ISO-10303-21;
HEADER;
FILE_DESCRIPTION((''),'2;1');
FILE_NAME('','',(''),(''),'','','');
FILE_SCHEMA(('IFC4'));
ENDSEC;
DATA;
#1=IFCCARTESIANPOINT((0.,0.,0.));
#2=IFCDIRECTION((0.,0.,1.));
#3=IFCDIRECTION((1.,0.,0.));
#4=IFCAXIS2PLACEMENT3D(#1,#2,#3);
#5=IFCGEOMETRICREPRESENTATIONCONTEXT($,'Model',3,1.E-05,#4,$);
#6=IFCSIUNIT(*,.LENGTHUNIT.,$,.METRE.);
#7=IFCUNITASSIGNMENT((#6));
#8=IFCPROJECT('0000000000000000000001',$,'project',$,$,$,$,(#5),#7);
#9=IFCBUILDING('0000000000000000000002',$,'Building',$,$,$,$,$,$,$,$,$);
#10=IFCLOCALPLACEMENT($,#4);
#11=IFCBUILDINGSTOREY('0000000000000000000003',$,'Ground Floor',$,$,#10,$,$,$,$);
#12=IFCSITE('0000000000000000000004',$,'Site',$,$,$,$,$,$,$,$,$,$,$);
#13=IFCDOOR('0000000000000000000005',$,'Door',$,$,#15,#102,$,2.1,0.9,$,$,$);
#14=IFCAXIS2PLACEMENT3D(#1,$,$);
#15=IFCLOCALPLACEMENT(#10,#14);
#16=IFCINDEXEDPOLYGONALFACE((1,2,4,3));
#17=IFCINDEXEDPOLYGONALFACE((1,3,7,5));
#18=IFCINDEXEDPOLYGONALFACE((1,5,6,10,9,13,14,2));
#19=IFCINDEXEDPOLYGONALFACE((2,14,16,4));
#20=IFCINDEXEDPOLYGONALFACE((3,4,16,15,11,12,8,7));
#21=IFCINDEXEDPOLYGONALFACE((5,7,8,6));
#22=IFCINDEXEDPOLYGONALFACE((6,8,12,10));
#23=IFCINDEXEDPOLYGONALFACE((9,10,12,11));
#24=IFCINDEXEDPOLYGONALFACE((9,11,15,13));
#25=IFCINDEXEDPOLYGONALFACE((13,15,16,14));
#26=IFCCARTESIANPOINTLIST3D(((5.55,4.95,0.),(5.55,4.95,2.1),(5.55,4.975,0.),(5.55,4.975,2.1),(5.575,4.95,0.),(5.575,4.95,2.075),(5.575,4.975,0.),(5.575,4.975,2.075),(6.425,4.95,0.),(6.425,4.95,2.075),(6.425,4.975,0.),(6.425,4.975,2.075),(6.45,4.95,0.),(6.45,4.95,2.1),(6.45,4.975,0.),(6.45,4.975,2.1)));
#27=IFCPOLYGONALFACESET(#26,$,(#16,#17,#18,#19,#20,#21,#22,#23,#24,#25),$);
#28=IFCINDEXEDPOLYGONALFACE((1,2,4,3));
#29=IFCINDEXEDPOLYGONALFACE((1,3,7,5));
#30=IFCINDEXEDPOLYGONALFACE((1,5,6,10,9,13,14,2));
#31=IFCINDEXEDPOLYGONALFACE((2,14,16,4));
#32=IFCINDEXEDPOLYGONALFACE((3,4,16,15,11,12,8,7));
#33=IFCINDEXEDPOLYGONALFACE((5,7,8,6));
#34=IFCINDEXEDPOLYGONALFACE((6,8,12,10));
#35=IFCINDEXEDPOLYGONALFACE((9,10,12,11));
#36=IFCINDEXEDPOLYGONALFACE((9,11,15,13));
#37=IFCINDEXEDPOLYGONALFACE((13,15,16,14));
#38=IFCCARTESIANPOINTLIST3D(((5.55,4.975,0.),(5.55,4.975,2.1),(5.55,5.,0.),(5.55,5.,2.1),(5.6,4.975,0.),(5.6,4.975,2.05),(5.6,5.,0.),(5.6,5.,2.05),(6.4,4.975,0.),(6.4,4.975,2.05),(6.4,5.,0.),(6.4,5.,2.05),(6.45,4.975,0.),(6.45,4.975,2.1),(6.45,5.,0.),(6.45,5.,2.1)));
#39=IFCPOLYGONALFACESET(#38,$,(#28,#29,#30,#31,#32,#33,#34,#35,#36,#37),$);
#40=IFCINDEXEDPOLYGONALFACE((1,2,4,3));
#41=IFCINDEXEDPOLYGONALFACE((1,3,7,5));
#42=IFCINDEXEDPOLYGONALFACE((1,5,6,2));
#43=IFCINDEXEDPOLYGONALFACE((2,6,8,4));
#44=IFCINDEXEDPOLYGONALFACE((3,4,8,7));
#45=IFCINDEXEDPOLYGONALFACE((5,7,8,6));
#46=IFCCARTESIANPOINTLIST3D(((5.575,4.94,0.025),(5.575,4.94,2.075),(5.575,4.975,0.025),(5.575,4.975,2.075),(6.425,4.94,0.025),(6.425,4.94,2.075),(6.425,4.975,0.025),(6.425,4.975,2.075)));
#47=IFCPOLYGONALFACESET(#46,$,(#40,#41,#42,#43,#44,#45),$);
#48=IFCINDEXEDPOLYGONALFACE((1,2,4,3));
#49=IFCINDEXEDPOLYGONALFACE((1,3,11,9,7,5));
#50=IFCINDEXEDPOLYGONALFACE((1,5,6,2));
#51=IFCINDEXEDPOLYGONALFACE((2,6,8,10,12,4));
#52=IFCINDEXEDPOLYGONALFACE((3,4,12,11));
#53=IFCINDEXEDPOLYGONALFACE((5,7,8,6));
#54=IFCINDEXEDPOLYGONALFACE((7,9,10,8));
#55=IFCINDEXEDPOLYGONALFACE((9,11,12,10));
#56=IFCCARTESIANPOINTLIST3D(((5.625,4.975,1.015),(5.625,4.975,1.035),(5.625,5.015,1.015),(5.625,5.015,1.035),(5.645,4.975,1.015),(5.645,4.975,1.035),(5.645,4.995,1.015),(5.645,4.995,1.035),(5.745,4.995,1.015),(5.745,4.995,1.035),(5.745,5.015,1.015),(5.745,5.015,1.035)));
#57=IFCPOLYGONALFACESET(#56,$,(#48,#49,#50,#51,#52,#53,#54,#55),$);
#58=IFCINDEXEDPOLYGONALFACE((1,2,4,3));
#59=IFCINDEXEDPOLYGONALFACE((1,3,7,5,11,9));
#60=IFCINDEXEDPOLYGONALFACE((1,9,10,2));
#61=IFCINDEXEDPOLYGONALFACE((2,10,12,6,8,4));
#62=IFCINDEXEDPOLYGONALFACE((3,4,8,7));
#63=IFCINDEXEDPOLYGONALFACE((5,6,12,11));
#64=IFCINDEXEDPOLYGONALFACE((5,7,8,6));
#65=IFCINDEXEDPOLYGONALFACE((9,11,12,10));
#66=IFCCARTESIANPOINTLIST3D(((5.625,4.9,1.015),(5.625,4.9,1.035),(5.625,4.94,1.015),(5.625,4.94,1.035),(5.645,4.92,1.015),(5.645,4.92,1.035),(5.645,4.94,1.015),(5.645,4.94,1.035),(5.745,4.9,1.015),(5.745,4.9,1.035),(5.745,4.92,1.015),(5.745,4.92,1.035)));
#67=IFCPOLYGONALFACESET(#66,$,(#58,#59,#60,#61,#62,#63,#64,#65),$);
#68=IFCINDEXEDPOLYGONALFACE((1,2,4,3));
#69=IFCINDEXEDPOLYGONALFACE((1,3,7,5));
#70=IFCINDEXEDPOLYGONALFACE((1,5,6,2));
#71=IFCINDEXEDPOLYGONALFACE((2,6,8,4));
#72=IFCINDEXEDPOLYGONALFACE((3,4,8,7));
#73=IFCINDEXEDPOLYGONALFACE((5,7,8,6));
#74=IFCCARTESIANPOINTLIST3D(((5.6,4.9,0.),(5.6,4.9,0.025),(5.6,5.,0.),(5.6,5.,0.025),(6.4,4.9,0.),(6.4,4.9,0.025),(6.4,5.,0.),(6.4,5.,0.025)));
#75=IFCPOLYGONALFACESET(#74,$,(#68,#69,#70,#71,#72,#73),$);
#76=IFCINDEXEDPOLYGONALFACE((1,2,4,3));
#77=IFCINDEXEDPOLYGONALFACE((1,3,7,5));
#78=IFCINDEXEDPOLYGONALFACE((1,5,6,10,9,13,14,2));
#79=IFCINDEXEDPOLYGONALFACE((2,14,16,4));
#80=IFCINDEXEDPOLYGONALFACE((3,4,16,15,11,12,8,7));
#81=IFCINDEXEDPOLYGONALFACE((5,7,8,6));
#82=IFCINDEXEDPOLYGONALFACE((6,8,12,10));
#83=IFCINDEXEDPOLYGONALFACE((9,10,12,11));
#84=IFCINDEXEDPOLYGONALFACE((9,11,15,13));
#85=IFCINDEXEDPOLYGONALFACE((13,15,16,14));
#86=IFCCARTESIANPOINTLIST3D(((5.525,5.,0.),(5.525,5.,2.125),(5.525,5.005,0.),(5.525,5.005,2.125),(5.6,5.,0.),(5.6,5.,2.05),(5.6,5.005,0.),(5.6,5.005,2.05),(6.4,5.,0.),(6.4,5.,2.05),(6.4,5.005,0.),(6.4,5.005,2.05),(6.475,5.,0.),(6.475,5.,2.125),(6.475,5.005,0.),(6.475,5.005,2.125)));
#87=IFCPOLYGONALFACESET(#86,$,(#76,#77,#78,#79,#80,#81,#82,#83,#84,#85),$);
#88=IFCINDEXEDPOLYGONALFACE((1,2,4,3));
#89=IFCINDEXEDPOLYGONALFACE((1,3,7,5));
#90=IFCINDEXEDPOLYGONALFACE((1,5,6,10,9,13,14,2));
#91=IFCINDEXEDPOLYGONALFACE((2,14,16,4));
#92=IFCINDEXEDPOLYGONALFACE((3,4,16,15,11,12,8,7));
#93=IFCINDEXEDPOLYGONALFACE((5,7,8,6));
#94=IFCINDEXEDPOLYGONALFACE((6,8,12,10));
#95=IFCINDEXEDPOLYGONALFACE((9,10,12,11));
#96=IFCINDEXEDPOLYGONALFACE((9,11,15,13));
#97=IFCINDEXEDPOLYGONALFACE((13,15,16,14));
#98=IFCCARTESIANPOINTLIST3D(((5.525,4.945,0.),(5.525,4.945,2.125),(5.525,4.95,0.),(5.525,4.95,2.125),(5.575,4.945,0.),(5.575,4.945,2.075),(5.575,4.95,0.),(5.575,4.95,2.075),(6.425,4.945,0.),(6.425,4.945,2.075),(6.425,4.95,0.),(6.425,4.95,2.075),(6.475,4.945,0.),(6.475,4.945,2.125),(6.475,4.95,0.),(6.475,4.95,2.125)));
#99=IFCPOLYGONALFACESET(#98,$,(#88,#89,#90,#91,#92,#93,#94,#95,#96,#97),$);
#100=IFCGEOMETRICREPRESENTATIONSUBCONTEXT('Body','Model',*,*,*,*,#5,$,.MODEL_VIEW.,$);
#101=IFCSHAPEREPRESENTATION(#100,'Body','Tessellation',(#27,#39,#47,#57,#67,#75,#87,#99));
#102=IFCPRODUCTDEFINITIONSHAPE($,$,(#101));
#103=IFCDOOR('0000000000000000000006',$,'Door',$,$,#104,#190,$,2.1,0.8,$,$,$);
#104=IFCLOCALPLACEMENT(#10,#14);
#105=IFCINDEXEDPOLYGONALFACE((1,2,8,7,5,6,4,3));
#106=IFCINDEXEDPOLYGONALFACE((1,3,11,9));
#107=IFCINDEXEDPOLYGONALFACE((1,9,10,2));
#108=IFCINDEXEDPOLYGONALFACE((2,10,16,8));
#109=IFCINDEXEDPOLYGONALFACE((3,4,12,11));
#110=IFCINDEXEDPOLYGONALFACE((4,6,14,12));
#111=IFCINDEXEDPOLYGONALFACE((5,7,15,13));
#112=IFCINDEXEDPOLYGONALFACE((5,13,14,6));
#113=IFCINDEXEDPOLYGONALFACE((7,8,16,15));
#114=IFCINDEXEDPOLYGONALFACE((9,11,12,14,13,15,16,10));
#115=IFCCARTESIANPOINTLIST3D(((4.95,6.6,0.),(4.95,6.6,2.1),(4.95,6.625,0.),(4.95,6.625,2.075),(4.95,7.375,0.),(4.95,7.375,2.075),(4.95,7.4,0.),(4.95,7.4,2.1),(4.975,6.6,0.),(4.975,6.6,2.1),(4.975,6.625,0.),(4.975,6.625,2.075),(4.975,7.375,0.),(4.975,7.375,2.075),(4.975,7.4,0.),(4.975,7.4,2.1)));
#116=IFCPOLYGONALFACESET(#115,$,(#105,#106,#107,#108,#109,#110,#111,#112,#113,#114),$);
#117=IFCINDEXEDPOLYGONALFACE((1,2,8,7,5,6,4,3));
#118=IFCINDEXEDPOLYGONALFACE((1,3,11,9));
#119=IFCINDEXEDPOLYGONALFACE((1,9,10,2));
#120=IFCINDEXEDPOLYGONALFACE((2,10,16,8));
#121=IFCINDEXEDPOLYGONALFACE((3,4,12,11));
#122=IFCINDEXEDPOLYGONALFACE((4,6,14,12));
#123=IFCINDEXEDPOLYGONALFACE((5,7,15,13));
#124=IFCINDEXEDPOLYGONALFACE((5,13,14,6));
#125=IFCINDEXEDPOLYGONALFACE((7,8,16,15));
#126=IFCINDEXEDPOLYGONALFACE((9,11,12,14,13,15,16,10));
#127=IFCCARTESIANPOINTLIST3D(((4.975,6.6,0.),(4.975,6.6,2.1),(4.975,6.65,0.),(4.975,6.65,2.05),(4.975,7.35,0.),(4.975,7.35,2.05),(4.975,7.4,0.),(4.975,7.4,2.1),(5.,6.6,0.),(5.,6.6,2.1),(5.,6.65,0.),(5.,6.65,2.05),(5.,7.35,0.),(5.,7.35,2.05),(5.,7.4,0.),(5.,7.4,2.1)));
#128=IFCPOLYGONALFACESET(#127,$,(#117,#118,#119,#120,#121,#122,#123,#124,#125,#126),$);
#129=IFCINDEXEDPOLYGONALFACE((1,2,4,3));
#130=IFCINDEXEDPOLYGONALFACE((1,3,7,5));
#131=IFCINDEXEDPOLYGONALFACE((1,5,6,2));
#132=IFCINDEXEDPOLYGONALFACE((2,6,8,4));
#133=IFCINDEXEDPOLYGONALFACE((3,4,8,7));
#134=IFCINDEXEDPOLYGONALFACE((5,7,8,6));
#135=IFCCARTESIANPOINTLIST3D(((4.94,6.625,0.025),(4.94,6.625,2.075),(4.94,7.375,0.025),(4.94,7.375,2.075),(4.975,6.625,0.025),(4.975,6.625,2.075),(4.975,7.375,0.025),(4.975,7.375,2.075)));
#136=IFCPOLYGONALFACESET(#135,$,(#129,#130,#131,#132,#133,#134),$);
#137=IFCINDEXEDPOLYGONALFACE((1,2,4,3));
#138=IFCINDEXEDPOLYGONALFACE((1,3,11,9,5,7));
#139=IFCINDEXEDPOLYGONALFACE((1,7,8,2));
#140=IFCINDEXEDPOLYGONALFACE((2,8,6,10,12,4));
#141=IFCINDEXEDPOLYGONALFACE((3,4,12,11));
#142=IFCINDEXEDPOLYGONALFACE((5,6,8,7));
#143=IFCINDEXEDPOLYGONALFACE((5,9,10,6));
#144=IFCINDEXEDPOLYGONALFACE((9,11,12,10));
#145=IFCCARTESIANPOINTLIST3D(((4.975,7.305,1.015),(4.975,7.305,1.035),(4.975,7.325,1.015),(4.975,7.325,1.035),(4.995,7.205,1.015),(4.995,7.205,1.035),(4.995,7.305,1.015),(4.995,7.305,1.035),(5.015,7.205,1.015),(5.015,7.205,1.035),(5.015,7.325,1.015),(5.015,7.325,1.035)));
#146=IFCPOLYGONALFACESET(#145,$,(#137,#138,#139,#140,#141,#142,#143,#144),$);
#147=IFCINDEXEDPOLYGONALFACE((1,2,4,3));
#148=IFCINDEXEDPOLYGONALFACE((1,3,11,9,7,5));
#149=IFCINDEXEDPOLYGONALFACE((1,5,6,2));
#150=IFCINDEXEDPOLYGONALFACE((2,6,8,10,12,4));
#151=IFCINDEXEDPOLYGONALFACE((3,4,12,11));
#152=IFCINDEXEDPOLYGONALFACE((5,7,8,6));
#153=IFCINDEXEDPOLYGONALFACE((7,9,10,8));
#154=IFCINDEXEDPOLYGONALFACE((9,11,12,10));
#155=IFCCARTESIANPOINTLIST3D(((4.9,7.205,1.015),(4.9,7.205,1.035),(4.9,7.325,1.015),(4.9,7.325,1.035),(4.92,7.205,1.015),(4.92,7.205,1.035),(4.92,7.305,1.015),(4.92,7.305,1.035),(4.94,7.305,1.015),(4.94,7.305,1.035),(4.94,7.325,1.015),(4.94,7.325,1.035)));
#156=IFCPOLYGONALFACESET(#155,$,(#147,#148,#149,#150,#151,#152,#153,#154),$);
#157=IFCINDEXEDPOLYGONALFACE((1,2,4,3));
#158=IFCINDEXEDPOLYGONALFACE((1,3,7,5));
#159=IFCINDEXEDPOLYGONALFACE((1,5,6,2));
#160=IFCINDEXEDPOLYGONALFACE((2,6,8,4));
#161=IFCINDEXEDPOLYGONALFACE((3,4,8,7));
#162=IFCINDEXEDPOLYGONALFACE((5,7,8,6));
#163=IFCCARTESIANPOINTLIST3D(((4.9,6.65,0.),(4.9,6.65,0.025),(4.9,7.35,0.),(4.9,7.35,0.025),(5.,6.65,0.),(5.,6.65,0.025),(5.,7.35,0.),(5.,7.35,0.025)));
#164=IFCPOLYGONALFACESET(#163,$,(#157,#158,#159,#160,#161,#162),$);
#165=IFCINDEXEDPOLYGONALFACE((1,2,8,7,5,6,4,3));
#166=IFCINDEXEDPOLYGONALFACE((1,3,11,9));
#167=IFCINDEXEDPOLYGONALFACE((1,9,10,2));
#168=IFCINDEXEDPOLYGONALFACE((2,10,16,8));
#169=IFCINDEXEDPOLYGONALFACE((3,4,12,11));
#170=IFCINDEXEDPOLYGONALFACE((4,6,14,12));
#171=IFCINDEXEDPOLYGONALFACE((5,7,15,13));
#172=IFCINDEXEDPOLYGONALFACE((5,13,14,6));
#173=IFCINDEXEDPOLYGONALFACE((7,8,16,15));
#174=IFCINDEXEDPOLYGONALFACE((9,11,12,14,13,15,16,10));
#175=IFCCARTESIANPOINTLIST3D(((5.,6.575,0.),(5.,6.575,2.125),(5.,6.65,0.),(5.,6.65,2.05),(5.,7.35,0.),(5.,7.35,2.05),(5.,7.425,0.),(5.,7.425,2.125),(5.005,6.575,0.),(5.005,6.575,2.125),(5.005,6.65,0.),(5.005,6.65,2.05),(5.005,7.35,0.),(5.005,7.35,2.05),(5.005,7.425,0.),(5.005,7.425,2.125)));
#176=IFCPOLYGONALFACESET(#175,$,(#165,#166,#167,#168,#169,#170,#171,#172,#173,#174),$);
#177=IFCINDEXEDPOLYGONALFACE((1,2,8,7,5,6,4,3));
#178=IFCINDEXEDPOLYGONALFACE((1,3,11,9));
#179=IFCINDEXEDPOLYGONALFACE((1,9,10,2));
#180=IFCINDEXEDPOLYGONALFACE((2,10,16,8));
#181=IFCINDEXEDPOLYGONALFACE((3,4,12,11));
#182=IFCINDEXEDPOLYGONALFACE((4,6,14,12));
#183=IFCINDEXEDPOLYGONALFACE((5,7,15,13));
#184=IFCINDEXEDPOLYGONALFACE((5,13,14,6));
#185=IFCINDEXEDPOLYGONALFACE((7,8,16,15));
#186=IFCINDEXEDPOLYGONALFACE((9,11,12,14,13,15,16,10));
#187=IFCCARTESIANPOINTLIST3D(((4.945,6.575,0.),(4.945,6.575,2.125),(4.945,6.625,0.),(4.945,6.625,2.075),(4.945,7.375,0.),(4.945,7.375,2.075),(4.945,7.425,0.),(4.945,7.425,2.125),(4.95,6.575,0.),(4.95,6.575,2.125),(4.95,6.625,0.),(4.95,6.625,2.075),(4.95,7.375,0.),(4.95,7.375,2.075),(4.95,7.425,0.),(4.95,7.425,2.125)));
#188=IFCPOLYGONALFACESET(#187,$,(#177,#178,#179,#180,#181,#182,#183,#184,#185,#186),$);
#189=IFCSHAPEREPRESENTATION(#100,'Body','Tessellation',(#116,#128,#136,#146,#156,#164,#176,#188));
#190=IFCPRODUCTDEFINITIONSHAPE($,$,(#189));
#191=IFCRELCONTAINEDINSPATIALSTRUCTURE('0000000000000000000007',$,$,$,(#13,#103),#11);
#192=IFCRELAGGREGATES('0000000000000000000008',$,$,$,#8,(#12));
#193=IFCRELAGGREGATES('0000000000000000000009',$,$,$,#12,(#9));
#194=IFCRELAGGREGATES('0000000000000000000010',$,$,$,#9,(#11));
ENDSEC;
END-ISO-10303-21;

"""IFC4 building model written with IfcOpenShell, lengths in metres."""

from ifc_helpers import new_model, si_unit, frame, origin_with_axes, place, context, subcontext, project, spatial, line, indexed_curve, outline, extrude, element, save


model = new_model("IFC4")

# Units and contexts
model_context = context("Model", 3, precision=1e-05, world=origin_with_axes())
body_context = subcontext(model_context, "Body", "Model", "MODEL_VIEW")
ifc_project = project(units=[si_unit("LENGTHUNIT", "METRE")], contexts=[model_context])

# Site, building, storey
site = spatial("IfcSite", under=ifc_project, Name="Site")
building = spatial("IfcBuilding", under=site, Name="Building")
storey_placement = place(None, origin_with_axes())
storey = spatial("IfcBuildingStorey", under=building, at=storey_placement, Name="Ground Floor")

# Doors
door_1_placement = place(storey_placement, frame((6.45, 5.0, 0.0), z_axis=(0.0, 0.0, 1.0), x_axis=(-1.0, 0.0, 0.0)))
element("IfcDoor", 1, at=door_1_placement, inside=storey, Name="Door", OverallHeight=2.1, OverallWidth=0.9, context=body_context, shape_type="SweptSolid", body=[
    extrude(outline(indexed_curve([(0.0, 0.0), (0.0, 2.1), (0.9, 2.1), (0.9, 0.0), (0.875, 0.0), (0.875, 2.075), (0.025, 2.075), (0.025, 0.0)], segments=[line(1, 2, 3, 4, 5, 6, 7, 8, 1)])), frame((0.0, 0.025, 0.0), z_axis=(0.0, -1.0, 0.0), x_axis=(1.0, 0.0, 0.0)), (0.0, 0.0, -1.0), 0.025),
    extrude(outline(indexed_curve([(0.0, 0.0), (0.0, 2.1), (0.9, 2.1), (0.9, 0.0), (0.85, 0.0), (0.85, 2.05), (0.05, 2.05), (0.05, 0.0)], segments=[line(1, 2, 3, 4, 5, 6, 7, 8, 1)])), frame((0.0, 0.0, 0.0), z_axis=(0.0, -1.0, 0.0), x_axis=(1.0, 0.0, 0.0)), (0.0, 0.0, -1.0), 0.025),
    extrude(outline(indexed_curve([(0.0, 0.0), (0.85, 0.0), (0.85, 0.035), (0.0, 0.035)], segments=[line(1, 2, 3, 4, 1)])), frame((0.025, 0.025, 0.025), z_axis=(0.0, 0.0, 1.0), x_axis=(1.0, 0.0, 0.0)), (0.0, 0.0, 1.0), 2.05),
    extrude(outline(indexed_curve([(0.0, 0.0), (0.0, -0.04), (-0.12, -0.04), (-0.12, -0.02), (-0.02, -0.02), (-0.02, 0.0)], segments=[line(1, 2, 3, 4, 5, 6, 1)])), frame((0.825, 0.025, 1.015), z_axis=(0.0, 0.0, 1.0), x_axis=(1.0, 0.0, 0.0)), (0.0, 0.0, 1.0), 0.02),
    extrude(outline(indexed_curve([(0.0, 0.0), (0.0, 0.04), (-0.12, 0.04), (-0.12, 0.02), (-0.02, 0.02), (-0.02, 0.0)], segments=[line(1, 2, 3, 4, 5, 6, 1)])), frame((0.825, 0.06, 1.015), z_axis=(0.0, 0.0, 1.0), x_axis=(1.0, 0.0, 0.0)), (0.0, 0.0, 1.0), 0.02),
    extrude(outline(indexed_curve([(0.0, 0.0), (0.8, 0.0), (0.8, 0.1), (0.0, 0.1)], segments=[line(1, 2, 3, 4, 1)])), frame((0.05, 0.0, 0.0), z_axis=(0.0, 0.0, 1.0), x_axis=(1.0, 0.0, 0.0)), (0.0, 0.0, 1.0), 0.025),
    extrude(outline(indexed_curve([(0.0, 0.0), (0.0, 2.125), (0.95, 2.125), (0.95, 0.0), (0.875, 0.0), (0.875, 2.05), (0.075, 2.05), (0.075, 0.0)], segments=[line(1, 2, 3, 4, 5, 6, 7, 8, 1)])), frame((-0.025, -0.005, 0.0), z_axis=(0.0, -1.0, 0.0), x_axis=(1.0, 0.0, 0.0)), (0.0, 0.0, -1.0), 0.005),
    extrude(outline(indexed_curve([(0.0, 0.0), (0.0, 2.125), (0.95, 2.125), (0.95, 0.0), (0.9, 0.0), (0.9, 2.075), (0.05, 2.075), (0.05, 0.0)], segments=[line(1, 2, 3, 4, 5, 6, 7, 8, 1)])), frame((-0.025, 0.05, 0.0), z_axis=(0.0, -1.0, 0.0), x_axis=(1.0, 0.0, 0.0)), (0.0, 0.0, -1.0), 0.005),
])
door_2_placement = place(storey_placement, frame((5.0, 6.6, 0.0), z_axis=(0.0, 0.0, 1.0), x_axis=(0.0, 1.0, 0.0)))
element("IfcDoor", 2, at=door_2_placement, inside=storey, Name="Door", OverallHeight=2.1, OverallWidth=0.8, context=body_context, shape_type="SweptSolid", body=[
    extrude(outline(indexed_curve([(0.0, 0.0), (0.0, 2.1), (0.8, 2.1), (0.8, 0.0), (0.775, 0.0), (0.775, 2.075), (0.025, 2.075), (0.025, 0.0)], segments=[line(1, 2, 3, 4, 5, 6, 7, 8, 1)])), frame((0.0, 0.025, 0.0), z_axis=(0.0, -1.0, 0.0), x_axis=(1.0, 0.0, 0.0)), (0.0, 0.0, -1.0), 0.025),
    extrude(outline(indexed_curve([(0.0, 0.0), (0.0, 2.1), (0.8, 2.1), (0.8, 0.0), (0.75, 0.0), (0.75, 2.05), (0.05, 2.05), (0.05, 0.0)], segments=[line(1, 2, 3, 4, 5, 6, 7, 8, 1)])), frame((0.0, 0.0, 0.0), z_axis=(0.0, -1.0, 0.0), x_axis=(1.0, 0.0, 0.0)), (0.0, 0.0, -1.0), 0.025),
    extrude(outline(indexed_curve([(0.0, 0.0), (0.75, 0.0), (0.75, 0.035), (0.0, 0.035)], segments=[line(1, 2, 3, 4, 1)])), frame((0.025, 0.025, 0.025), z_axis=(0.0, 0.0, 1.0), x_axis=(1.0, 0.0, 0.0)), (0.0, 0.0, 1.0), 2.05),
    extrude(outline(indexed_curve([(0.0, 0.0), (0.0, -0.04), (-0.12, -0.04), (-0.12, -0.02), (-0.02, -0.02), (-0.02, 0.0)], segments=[line(1, 2, 3, 4, 5, 6, 1)])), frame((0.725, 0.025, 1.015), z_axis=(0.0, 0.0, 1.0), x_axis=(1.0, 0.0, 0.0)), (0.0, 0.0, 1.0), 0.02),
    extrude(outline(indexed_curve([(0.0, 0.0), (0.0, 0.04), (-0.12, 0.04), (-0.12, 0.02), (-0.02, 0.02), (-0.02, 0.0)], segments=[line(1, 2, 3, 4, 5, 6, 1)])), frame((0.725, 0.06, 1.015), z_axis=(0.0, 0.0, 1.0), x_axis=(1.0, 0.0, 0.0)), (0.0, 0.0, 1.0), 0.02),
    extrude(outline(indexed_curve([(0.0, 0.0), (0.7, 0.0), (0.7, 0.1), (0.0, 0.1)], segments=[line(1, 2, 3, 4, 1)])), frame((0.05, 0.0, 0.0), z_axis=(0.0, 0.0, 1.0), x_axis=(1.0, 0.0, 0.0)), (0.0, 0.0, 1.0), 0.025),
    extrude(outline(indexed_curve([(0.0, 0.0), (0.0, 2.125), (0.85, 2.125), (0.85, 0.0), (0.775, 0.0), (0.775, 2.05), (0.075, 2.05), (0.075, 0.0)], segments=[line(1, 2, 3, 4, 5, 6, 7, 8, 1)])), frame((-0.025, -0.005, 0.0), z_axis=(0.0, -1.0, 0.0), x_axis=(1.0, 0.0, 0.0)), (0.0, 0.0, -1.0), 0.005),
    extrude(outline(indexed_curve([(0.0, 0.0), (0.0, 2.125), (0.85, 2.125), (0.85, 0.0), (0.8, 0.0), (0.8, 2.075), (0.05, 2.075), (0.05, 0.0)], segments=[line(1, 2, 3, 4, 5, 6, 7, 8, 1)])), frame((-0.025, 0.05, 0.0), z_axis=(0.0, -1.0, 0.0), x_axis=(1.0, 0.0, 0.0)), (0.0, 0.0, -1.0), 0.005),
])

save(model, "model.ifc")
